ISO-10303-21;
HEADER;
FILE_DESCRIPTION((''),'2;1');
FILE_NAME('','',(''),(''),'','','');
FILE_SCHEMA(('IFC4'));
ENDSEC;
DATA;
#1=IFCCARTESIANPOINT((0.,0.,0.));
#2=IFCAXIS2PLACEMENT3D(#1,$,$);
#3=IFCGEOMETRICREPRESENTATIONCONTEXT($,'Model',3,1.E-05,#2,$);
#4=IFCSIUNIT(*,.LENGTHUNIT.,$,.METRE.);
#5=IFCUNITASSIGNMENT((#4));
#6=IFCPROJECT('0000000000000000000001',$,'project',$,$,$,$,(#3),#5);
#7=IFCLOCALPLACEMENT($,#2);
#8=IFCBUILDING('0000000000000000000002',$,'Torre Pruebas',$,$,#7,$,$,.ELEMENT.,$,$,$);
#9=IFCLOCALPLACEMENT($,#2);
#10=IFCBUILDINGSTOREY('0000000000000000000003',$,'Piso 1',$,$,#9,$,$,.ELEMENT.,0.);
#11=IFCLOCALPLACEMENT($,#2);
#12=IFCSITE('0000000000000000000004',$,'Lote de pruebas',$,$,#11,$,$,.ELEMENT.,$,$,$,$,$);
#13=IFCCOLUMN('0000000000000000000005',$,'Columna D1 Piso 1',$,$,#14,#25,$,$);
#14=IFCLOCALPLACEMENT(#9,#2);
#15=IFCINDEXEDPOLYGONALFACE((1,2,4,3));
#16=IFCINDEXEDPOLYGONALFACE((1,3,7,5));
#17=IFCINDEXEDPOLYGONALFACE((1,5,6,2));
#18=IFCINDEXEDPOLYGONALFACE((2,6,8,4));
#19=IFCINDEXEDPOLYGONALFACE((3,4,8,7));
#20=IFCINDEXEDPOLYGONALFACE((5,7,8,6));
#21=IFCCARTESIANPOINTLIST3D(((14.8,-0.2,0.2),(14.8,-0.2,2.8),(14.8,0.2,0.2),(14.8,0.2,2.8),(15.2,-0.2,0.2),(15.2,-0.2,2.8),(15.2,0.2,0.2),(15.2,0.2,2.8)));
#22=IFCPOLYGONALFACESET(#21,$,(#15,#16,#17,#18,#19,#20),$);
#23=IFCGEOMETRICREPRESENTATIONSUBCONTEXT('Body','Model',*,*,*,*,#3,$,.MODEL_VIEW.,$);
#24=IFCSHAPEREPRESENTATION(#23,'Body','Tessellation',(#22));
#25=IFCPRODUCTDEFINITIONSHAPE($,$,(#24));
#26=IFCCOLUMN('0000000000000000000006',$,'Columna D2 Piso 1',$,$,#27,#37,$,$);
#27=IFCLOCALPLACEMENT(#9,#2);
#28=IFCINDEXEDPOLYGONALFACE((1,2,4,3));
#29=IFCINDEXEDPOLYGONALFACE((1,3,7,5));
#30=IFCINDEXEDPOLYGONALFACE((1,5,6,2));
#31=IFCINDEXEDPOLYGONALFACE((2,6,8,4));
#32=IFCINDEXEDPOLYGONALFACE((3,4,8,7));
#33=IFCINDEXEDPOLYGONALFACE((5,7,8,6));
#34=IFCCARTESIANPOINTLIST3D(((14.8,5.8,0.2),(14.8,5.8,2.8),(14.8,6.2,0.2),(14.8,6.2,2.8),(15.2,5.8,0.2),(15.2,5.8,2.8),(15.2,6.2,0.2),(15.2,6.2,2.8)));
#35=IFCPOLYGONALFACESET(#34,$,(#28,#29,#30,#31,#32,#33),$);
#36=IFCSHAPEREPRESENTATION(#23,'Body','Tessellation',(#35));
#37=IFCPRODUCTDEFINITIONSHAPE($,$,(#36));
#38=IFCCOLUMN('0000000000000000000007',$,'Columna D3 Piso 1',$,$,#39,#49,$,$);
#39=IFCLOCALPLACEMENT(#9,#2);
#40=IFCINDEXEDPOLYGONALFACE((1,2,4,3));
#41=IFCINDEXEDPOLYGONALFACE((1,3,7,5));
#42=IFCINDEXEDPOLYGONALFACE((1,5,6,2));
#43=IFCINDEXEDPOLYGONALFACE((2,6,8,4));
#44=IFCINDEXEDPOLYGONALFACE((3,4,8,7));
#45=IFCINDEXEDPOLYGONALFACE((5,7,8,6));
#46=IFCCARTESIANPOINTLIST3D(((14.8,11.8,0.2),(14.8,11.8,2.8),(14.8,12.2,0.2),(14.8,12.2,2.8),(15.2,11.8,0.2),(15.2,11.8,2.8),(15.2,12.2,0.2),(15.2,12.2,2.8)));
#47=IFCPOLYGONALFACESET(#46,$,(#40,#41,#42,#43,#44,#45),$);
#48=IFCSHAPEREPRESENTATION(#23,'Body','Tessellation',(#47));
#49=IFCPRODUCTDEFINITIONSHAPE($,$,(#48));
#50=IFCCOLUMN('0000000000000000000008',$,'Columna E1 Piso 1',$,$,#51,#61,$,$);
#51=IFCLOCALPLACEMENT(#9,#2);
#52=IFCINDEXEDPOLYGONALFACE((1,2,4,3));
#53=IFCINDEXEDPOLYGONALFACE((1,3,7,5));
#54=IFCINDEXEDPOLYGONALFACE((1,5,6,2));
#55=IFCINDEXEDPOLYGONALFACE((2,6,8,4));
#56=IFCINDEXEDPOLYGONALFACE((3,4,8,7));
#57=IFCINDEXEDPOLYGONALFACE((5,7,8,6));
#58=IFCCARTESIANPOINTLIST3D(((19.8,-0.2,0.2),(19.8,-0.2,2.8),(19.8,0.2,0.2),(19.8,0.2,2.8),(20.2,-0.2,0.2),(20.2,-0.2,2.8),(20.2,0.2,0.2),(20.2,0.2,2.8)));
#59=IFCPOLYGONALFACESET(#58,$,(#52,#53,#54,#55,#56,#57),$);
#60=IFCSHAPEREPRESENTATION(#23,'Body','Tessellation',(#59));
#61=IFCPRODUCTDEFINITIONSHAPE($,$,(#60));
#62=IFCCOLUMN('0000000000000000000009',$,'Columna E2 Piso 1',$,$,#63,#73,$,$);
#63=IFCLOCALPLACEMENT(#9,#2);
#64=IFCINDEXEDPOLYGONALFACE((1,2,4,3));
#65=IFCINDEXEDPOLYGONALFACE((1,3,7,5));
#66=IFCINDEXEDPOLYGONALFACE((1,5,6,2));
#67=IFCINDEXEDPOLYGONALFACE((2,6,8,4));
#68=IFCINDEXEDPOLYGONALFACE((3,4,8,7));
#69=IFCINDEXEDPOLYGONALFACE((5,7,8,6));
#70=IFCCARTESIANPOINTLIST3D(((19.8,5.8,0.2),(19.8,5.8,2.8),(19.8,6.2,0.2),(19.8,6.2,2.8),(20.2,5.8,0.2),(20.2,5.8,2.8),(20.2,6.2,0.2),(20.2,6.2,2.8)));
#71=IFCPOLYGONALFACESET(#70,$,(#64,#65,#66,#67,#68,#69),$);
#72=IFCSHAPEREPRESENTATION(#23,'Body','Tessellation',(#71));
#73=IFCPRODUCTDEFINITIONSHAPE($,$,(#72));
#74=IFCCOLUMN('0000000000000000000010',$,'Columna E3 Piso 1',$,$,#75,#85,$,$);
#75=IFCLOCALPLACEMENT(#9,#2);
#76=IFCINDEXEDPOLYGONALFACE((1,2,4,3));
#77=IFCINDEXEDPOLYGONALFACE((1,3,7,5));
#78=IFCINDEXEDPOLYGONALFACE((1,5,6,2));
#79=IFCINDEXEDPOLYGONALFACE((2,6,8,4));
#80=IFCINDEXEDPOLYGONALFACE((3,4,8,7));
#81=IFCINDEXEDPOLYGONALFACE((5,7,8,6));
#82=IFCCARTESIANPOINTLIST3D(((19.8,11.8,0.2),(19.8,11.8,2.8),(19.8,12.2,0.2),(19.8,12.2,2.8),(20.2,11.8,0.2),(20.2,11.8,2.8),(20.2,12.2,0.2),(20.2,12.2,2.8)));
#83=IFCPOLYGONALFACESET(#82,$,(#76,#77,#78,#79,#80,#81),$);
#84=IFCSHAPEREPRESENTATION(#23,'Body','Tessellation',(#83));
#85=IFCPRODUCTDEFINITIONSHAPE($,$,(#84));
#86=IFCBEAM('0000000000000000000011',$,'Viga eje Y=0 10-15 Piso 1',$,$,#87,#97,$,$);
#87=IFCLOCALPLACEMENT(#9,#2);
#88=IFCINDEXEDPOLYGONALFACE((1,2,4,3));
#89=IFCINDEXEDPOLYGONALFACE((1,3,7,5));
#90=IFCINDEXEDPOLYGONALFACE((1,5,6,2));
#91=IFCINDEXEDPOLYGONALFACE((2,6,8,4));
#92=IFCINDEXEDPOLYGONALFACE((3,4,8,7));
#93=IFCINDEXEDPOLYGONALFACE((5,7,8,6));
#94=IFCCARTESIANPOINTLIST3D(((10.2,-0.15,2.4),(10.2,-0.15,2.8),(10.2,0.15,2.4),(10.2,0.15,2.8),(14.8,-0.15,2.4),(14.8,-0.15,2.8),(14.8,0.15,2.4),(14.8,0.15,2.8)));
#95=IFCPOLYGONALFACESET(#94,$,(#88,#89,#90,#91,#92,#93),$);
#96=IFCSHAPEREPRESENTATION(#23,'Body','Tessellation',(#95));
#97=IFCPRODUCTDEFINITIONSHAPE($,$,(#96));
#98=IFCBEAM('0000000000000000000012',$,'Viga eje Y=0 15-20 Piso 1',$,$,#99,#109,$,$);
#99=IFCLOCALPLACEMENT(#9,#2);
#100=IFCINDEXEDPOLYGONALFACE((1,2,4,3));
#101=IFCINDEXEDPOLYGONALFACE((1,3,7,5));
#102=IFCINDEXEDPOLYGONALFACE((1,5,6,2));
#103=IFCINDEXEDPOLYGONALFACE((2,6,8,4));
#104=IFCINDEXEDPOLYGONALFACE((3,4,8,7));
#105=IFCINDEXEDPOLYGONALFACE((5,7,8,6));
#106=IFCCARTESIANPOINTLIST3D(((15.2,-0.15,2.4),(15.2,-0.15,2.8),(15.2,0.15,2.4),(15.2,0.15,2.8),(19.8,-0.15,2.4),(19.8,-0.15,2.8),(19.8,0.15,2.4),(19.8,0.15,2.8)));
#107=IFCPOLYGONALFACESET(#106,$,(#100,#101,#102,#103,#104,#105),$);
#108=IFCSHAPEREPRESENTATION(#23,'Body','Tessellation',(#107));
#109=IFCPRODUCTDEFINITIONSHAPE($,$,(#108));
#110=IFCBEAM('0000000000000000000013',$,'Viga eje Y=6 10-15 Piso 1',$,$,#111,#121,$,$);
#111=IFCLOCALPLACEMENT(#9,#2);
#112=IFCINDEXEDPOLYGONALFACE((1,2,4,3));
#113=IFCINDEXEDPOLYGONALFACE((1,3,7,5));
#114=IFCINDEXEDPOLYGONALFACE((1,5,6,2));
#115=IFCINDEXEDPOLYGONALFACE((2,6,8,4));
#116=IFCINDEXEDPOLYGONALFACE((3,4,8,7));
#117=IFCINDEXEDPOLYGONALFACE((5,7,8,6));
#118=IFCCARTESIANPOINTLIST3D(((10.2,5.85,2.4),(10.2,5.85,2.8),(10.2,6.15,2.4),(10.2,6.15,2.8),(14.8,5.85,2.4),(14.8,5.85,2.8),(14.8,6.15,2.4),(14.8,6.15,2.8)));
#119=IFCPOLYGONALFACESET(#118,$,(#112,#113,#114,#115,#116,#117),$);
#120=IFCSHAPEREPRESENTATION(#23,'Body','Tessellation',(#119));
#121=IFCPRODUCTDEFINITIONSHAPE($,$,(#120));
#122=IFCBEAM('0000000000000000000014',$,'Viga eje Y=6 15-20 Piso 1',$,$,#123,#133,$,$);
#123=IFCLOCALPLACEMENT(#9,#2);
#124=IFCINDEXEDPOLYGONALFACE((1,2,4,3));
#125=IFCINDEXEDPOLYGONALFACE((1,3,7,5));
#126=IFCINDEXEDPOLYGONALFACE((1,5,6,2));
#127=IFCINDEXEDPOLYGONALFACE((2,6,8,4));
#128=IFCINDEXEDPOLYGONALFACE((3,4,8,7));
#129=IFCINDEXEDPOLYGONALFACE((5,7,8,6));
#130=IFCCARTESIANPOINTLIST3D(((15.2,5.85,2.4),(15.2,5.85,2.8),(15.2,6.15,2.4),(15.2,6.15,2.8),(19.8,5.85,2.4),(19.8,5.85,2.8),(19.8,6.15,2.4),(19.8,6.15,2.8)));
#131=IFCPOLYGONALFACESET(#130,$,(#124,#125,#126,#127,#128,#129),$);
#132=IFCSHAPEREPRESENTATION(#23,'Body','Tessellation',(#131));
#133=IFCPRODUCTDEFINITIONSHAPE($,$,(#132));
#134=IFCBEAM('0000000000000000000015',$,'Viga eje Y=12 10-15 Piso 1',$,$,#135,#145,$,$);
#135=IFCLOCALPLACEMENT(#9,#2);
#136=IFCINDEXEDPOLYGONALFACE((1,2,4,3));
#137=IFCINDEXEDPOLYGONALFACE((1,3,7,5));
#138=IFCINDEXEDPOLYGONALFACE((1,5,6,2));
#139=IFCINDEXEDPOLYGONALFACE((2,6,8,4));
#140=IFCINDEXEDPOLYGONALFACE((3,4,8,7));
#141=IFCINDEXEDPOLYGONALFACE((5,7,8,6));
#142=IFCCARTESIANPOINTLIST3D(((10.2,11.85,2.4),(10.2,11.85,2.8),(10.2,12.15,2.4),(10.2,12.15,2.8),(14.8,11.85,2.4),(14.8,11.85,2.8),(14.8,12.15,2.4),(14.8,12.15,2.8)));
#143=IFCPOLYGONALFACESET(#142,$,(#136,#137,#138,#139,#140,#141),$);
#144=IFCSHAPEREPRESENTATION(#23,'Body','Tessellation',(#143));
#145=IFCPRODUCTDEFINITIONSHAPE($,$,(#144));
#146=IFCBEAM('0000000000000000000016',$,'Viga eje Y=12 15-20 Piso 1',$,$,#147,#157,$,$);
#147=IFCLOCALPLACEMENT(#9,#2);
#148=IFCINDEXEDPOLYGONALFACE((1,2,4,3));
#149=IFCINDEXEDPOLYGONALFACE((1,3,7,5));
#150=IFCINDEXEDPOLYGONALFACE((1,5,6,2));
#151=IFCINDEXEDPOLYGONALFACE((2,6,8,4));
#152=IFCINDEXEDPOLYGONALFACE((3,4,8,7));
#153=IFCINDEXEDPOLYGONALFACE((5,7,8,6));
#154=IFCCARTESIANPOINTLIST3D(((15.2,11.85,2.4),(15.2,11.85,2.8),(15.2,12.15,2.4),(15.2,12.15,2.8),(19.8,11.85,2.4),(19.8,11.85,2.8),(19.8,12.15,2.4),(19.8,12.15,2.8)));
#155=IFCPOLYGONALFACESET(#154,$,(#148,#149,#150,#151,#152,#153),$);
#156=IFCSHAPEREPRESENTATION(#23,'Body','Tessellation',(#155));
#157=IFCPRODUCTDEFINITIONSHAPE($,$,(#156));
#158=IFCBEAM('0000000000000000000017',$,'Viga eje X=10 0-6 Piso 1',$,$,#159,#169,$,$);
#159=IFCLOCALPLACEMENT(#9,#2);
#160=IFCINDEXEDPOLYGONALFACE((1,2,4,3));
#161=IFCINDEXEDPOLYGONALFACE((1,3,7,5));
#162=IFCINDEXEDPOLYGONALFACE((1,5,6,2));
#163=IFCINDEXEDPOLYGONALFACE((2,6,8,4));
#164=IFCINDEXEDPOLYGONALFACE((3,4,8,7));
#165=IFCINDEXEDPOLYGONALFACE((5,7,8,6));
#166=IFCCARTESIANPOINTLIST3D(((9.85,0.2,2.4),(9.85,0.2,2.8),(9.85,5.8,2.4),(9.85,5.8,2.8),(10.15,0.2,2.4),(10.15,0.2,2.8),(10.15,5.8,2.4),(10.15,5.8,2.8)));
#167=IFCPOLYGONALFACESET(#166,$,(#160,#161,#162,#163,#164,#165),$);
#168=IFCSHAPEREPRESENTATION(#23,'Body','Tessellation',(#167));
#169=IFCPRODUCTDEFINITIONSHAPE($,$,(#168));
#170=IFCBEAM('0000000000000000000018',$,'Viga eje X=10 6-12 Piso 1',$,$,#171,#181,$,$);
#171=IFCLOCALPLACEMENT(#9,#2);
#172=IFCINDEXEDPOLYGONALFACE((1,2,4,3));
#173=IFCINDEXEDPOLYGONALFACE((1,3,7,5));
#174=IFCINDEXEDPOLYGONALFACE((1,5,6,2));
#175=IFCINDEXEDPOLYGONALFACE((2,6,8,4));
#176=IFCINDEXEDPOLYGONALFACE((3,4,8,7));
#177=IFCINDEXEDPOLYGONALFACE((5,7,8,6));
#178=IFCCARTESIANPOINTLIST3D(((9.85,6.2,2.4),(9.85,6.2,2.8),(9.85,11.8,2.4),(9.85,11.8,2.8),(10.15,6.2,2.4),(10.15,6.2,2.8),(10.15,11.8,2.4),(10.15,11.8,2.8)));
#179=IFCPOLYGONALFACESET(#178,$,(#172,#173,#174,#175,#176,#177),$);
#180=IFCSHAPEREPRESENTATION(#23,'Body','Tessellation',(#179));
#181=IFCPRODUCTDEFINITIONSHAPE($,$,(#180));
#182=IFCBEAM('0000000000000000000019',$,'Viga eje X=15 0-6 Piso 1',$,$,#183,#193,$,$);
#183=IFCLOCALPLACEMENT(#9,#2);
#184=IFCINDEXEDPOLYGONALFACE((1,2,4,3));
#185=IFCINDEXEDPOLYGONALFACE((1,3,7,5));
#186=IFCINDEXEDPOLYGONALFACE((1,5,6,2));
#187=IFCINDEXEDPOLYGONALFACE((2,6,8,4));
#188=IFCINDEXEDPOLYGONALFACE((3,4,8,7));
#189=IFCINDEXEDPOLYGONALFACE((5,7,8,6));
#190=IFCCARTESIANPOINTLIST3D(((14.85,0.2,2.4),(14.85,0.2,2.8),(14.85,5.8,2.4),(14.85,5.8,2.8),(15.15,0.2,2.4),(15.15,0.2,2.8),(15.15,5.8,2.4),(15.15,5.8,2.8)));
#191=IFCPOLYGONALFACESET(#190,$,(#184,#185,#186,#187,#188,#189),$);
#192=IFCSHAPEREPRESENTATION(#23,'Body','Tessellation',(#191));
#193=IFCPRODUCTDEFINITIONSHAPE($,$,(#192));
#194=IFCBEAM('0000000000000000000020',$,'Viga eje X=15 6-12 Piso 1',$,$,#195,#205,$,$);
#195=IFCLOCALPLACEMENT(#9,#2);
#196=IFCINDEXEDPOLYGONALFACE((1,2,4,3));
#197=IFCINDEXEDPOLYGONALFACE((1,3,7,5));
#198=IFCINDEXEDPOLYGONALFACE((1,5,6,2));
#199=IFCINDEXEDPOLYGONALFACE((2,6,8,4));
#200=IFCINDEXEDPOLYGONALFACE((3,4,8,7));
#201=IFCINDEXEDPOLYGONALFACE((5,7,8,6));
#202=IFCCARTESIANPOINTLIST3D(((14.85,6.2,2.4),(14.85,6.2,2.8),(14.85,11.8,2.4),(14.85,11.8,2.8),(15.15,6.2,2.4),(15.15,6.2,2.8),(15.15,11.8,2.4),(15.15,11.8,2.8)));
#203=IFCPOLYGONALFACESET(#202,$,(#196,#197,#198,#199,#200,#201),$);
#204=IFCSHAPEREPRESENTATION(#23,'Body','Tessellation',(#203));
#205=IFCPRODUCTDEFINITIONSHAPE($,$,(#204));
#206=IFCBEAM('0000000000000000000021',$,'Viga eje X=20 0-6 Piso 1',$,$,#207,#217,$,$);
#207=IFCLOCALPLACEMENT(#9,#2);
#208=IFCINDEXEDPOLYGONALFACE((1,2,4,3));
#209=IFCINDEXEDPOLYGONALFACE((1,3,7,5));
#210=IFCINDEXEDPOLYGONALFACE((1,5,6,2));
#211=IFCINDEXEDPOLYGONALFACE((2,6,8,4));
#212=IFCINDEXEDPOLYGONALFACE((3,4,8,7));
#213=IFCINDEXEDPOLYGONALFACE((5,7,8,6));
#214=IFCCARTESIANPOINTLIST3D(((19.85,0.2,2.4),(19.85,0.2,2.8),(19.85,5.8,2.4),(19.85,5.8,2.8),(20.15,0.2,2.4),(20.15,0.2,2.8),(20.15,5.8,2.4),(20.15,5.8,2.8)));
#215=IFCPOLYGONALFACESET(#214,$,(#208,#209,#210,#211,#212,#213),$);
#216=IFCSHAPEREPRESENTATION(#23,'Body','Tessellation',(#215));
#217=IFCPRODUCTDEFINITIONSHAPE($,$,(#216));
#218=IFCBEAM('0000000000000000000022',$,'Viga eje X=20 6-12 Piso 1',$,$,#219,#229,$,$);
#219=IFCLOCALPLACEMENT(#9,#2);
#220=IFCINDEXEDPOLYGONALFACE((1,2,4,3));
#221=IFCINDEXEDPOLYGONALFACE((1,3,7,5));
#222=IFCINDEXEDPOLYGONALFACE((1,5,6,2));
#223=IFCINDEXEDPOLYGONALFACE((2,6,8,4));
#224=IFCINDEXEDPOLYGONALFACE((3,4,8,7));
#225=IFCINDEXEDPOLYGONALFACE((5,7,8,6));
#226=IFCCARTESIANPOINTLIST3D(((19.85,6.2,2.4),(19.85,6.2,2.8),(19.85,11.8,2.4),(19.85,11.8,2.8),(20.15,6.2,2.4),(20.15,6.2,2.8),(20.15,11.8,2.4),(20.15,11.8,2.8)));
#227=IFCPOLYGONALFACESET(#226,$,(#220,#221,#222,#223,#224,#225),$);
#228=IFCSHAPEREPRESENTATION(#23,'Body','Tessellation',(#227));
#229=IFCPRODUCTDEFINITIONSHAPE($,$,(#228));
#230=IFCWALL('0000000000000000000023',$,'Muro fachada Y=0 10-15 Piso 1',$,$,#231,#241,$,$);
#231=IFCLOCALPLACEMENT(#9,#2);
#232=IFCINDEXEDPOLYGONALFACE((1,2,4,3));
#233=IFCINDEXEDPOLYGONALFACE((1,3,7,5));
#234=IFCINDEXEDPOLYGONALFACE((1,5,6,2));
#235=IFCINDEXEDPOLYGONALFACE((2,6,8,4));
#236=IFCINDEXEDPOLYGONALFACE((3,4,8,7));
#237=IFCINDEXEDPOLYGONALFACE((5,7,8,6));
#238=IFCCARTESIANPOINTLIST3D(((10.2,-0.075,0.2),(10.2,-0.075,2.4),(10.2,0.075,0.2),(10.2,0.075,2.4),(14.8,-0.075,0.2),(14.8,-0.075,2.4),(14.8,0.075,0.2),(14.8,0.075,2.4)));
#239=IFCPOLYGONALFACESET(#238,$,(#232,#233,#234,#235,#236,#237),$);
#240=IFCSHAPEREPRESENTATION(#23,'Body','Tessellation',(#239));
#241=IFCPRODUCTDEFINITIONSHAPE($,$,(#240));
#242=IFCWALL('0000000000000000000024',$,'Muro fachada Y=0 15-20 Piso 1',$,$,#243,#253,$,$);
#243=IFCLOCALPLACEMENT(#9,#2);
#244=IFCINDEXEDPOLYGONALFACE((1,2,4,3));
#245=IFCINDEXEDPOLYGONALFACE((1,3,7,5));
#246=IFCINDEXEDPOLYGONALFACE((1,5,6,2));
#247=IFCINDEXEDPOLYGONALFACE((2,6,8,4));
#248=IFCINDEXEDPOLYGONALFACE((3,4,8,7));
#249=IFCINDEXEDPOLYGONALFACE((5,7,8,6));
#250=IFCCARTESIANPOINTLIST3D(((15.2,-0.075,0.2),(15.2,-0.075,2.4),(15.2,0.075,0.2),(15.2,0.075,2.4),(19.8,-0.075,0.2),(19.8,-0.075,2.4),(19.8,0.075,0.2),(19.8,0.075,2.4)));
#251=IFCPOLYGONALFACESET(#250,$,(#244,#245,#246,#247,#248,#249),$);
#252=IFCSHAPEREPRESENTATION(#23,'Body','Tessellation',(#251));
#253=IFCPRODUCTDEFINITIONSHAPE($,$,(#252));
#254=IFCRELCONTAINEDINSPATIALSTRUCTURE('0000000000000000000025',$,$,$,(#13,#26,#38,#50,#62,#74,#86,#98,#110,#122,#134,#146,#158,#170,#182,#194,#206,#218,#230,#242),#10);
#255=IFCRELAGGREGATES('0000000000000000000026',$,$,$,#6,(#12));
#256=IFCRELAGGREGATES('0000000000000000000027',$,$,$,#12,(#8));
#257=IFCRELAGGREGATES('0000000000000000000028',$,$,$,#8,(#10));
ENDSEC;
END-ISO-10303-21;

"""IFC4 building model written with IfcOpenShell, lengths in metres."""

from ifc_helpers import new_model, si_unit, frame, origin, origin_2d, place, context, subcontext, project, spatial, rectangle, extrude, element, save


model = new_model("IFC4")

# Units and contexts
model_context = context("Model", 3, precision=1e-05, world=origin())
body_context = subcontext(model_context, "Body", "Model", "MODEL_VIEW")
ifc_project = project(units=[si_unit("LENGTHUNIT", "METRE")], contexts=[model_context])

# Site, building, storey
site_placement = place(None, origin())
site = spatial("IfcSite", under=ifc_project, at=site_placement, Name="Lote de pruebas", CompositionType="ELEMENT")
building_placement = place(None, origin())
building = spatial("IfcBuilding", under=site, at=building_placement, Name="Torre Pruebas", CompositionType="ELEMENT")
storey_placement = place(None, origin())
storey = spatial("IfcBuildingStorey", under=building, at=storey_placement, Name="Piso 1", CompositionType="ELEMENT", Elevation=0.0)

# Columns
for number, where, name in (
    (1, (15.0, 0.0, 0.2), "Columna D1 Piso 1"),
    (2, (15.0, 6.0, 0.2), "Columna D2 Piso 1"),
    (3, (15.0, 12.0, 0.2), "Columna D3 Piso 1"),
    (4, (20.0, 0.0, 0.2), "Columna E1 Piso 1"),
    (5, (20.0, 6.0, 0.2), "Columna E2 Piso 1"),
    (6, (20.0, 12.0, 0.2), "Columna E3 Piso 1"),
):
    element("IfcColumn", number, at=place(None, frame(where)), inside=storey, Name=name, context=body_context, shape_type="SweptSolid", body=[
        extrude(rectangle(XDim=0.4, YDim=0.4, at=origin_2d()), origin(), (0.0, 0.0, 1.0), 2.6),
    ])

# Beams
for number, where, name in (
    (7, (12.5, 0.0, 2.4), "Viga eje Y=0 10-15 Piso 1"),
    (8, (17.5, 0.0, 2.4), "Viga eje Y=0 15-20 Piso 1"),
    (9, (12.5, 6.0, 2.4), "Viga eje Y=6 10-15 Piso 1"),
    (10, (17.5, 6.0, 2.4), "Viga eje Y=6 15-20 Piso 1"),
    (11, (12.5, 12.0, 2.4), "Viga eje Y=12 10-15 Piso 1"),
    (12, (17.5, 12.0, 2.4), "Viga eje Y=12 15-20 Piso 1"),
):
    element("IfcBeam", number, at=place(None, frame(where)), inside=storey, Name=name, context=body_context, shape_type="SweptSolid", body=[
        extrude(rectangle(XDim=4.6, YDim=0.3, at=origin_2d()), origin(), (0.0, 0.0, 1.0), 0.4),
    ])
for number, where, name in (
    (13, (10.0, 3.0, 2.4), "Viga eje X=10 0-6 Piso 1"),
    (14, (10.0, 9.0, 2.4), "Viga eje X=10 6-12 Piso 1"),
    (15, (15.0, 3.0, 2.4), "Viga eje X=15 0-6 Piso 1"),
    (16, (15.0, 9.0, 2.4), "Viga eje X=15 6-12 Piso 1"),
    (17, (20.0, 3.0, 2.4), "Viga eje X=20 0-6 Piso 1"),
    (18, (20.0, 9.0, 2.4), "Viga eje X=20 6-12 Piso 1"),
):
    element("IfcBeam", number, at=place(None, frame(where)), inside=storey, Name=name, context=body_context, shape_type="SweptSolid", body=[
        extrude(rectangle(XDim=0.3, YDim=5.6, at=origin_2d()), origin(), (0.0, 0.0, 1.0), 0.4),
    ])

# Walls
for number, where, name in (
    (19, (12.5, 0.0, 0.2), "Muro fachada Y=0 10-15 Piso 1"),
    (20, (17.5, 0.0, 0.2), "Muro fachada Y=0 15-20 Piso 1"),
):
    element("IfcWall", number, at=place(None, frame(where)), inside=storey, Name=name, context=body_context, shape_type="SweptSolid", body=[
        extrude(rectangle(XDim=4.6, YDim=0.15, at=origin_2d()), origin(), (0.0, 0.0, 1.0), 2.2),
    ])

save(model, "model.ifc")
